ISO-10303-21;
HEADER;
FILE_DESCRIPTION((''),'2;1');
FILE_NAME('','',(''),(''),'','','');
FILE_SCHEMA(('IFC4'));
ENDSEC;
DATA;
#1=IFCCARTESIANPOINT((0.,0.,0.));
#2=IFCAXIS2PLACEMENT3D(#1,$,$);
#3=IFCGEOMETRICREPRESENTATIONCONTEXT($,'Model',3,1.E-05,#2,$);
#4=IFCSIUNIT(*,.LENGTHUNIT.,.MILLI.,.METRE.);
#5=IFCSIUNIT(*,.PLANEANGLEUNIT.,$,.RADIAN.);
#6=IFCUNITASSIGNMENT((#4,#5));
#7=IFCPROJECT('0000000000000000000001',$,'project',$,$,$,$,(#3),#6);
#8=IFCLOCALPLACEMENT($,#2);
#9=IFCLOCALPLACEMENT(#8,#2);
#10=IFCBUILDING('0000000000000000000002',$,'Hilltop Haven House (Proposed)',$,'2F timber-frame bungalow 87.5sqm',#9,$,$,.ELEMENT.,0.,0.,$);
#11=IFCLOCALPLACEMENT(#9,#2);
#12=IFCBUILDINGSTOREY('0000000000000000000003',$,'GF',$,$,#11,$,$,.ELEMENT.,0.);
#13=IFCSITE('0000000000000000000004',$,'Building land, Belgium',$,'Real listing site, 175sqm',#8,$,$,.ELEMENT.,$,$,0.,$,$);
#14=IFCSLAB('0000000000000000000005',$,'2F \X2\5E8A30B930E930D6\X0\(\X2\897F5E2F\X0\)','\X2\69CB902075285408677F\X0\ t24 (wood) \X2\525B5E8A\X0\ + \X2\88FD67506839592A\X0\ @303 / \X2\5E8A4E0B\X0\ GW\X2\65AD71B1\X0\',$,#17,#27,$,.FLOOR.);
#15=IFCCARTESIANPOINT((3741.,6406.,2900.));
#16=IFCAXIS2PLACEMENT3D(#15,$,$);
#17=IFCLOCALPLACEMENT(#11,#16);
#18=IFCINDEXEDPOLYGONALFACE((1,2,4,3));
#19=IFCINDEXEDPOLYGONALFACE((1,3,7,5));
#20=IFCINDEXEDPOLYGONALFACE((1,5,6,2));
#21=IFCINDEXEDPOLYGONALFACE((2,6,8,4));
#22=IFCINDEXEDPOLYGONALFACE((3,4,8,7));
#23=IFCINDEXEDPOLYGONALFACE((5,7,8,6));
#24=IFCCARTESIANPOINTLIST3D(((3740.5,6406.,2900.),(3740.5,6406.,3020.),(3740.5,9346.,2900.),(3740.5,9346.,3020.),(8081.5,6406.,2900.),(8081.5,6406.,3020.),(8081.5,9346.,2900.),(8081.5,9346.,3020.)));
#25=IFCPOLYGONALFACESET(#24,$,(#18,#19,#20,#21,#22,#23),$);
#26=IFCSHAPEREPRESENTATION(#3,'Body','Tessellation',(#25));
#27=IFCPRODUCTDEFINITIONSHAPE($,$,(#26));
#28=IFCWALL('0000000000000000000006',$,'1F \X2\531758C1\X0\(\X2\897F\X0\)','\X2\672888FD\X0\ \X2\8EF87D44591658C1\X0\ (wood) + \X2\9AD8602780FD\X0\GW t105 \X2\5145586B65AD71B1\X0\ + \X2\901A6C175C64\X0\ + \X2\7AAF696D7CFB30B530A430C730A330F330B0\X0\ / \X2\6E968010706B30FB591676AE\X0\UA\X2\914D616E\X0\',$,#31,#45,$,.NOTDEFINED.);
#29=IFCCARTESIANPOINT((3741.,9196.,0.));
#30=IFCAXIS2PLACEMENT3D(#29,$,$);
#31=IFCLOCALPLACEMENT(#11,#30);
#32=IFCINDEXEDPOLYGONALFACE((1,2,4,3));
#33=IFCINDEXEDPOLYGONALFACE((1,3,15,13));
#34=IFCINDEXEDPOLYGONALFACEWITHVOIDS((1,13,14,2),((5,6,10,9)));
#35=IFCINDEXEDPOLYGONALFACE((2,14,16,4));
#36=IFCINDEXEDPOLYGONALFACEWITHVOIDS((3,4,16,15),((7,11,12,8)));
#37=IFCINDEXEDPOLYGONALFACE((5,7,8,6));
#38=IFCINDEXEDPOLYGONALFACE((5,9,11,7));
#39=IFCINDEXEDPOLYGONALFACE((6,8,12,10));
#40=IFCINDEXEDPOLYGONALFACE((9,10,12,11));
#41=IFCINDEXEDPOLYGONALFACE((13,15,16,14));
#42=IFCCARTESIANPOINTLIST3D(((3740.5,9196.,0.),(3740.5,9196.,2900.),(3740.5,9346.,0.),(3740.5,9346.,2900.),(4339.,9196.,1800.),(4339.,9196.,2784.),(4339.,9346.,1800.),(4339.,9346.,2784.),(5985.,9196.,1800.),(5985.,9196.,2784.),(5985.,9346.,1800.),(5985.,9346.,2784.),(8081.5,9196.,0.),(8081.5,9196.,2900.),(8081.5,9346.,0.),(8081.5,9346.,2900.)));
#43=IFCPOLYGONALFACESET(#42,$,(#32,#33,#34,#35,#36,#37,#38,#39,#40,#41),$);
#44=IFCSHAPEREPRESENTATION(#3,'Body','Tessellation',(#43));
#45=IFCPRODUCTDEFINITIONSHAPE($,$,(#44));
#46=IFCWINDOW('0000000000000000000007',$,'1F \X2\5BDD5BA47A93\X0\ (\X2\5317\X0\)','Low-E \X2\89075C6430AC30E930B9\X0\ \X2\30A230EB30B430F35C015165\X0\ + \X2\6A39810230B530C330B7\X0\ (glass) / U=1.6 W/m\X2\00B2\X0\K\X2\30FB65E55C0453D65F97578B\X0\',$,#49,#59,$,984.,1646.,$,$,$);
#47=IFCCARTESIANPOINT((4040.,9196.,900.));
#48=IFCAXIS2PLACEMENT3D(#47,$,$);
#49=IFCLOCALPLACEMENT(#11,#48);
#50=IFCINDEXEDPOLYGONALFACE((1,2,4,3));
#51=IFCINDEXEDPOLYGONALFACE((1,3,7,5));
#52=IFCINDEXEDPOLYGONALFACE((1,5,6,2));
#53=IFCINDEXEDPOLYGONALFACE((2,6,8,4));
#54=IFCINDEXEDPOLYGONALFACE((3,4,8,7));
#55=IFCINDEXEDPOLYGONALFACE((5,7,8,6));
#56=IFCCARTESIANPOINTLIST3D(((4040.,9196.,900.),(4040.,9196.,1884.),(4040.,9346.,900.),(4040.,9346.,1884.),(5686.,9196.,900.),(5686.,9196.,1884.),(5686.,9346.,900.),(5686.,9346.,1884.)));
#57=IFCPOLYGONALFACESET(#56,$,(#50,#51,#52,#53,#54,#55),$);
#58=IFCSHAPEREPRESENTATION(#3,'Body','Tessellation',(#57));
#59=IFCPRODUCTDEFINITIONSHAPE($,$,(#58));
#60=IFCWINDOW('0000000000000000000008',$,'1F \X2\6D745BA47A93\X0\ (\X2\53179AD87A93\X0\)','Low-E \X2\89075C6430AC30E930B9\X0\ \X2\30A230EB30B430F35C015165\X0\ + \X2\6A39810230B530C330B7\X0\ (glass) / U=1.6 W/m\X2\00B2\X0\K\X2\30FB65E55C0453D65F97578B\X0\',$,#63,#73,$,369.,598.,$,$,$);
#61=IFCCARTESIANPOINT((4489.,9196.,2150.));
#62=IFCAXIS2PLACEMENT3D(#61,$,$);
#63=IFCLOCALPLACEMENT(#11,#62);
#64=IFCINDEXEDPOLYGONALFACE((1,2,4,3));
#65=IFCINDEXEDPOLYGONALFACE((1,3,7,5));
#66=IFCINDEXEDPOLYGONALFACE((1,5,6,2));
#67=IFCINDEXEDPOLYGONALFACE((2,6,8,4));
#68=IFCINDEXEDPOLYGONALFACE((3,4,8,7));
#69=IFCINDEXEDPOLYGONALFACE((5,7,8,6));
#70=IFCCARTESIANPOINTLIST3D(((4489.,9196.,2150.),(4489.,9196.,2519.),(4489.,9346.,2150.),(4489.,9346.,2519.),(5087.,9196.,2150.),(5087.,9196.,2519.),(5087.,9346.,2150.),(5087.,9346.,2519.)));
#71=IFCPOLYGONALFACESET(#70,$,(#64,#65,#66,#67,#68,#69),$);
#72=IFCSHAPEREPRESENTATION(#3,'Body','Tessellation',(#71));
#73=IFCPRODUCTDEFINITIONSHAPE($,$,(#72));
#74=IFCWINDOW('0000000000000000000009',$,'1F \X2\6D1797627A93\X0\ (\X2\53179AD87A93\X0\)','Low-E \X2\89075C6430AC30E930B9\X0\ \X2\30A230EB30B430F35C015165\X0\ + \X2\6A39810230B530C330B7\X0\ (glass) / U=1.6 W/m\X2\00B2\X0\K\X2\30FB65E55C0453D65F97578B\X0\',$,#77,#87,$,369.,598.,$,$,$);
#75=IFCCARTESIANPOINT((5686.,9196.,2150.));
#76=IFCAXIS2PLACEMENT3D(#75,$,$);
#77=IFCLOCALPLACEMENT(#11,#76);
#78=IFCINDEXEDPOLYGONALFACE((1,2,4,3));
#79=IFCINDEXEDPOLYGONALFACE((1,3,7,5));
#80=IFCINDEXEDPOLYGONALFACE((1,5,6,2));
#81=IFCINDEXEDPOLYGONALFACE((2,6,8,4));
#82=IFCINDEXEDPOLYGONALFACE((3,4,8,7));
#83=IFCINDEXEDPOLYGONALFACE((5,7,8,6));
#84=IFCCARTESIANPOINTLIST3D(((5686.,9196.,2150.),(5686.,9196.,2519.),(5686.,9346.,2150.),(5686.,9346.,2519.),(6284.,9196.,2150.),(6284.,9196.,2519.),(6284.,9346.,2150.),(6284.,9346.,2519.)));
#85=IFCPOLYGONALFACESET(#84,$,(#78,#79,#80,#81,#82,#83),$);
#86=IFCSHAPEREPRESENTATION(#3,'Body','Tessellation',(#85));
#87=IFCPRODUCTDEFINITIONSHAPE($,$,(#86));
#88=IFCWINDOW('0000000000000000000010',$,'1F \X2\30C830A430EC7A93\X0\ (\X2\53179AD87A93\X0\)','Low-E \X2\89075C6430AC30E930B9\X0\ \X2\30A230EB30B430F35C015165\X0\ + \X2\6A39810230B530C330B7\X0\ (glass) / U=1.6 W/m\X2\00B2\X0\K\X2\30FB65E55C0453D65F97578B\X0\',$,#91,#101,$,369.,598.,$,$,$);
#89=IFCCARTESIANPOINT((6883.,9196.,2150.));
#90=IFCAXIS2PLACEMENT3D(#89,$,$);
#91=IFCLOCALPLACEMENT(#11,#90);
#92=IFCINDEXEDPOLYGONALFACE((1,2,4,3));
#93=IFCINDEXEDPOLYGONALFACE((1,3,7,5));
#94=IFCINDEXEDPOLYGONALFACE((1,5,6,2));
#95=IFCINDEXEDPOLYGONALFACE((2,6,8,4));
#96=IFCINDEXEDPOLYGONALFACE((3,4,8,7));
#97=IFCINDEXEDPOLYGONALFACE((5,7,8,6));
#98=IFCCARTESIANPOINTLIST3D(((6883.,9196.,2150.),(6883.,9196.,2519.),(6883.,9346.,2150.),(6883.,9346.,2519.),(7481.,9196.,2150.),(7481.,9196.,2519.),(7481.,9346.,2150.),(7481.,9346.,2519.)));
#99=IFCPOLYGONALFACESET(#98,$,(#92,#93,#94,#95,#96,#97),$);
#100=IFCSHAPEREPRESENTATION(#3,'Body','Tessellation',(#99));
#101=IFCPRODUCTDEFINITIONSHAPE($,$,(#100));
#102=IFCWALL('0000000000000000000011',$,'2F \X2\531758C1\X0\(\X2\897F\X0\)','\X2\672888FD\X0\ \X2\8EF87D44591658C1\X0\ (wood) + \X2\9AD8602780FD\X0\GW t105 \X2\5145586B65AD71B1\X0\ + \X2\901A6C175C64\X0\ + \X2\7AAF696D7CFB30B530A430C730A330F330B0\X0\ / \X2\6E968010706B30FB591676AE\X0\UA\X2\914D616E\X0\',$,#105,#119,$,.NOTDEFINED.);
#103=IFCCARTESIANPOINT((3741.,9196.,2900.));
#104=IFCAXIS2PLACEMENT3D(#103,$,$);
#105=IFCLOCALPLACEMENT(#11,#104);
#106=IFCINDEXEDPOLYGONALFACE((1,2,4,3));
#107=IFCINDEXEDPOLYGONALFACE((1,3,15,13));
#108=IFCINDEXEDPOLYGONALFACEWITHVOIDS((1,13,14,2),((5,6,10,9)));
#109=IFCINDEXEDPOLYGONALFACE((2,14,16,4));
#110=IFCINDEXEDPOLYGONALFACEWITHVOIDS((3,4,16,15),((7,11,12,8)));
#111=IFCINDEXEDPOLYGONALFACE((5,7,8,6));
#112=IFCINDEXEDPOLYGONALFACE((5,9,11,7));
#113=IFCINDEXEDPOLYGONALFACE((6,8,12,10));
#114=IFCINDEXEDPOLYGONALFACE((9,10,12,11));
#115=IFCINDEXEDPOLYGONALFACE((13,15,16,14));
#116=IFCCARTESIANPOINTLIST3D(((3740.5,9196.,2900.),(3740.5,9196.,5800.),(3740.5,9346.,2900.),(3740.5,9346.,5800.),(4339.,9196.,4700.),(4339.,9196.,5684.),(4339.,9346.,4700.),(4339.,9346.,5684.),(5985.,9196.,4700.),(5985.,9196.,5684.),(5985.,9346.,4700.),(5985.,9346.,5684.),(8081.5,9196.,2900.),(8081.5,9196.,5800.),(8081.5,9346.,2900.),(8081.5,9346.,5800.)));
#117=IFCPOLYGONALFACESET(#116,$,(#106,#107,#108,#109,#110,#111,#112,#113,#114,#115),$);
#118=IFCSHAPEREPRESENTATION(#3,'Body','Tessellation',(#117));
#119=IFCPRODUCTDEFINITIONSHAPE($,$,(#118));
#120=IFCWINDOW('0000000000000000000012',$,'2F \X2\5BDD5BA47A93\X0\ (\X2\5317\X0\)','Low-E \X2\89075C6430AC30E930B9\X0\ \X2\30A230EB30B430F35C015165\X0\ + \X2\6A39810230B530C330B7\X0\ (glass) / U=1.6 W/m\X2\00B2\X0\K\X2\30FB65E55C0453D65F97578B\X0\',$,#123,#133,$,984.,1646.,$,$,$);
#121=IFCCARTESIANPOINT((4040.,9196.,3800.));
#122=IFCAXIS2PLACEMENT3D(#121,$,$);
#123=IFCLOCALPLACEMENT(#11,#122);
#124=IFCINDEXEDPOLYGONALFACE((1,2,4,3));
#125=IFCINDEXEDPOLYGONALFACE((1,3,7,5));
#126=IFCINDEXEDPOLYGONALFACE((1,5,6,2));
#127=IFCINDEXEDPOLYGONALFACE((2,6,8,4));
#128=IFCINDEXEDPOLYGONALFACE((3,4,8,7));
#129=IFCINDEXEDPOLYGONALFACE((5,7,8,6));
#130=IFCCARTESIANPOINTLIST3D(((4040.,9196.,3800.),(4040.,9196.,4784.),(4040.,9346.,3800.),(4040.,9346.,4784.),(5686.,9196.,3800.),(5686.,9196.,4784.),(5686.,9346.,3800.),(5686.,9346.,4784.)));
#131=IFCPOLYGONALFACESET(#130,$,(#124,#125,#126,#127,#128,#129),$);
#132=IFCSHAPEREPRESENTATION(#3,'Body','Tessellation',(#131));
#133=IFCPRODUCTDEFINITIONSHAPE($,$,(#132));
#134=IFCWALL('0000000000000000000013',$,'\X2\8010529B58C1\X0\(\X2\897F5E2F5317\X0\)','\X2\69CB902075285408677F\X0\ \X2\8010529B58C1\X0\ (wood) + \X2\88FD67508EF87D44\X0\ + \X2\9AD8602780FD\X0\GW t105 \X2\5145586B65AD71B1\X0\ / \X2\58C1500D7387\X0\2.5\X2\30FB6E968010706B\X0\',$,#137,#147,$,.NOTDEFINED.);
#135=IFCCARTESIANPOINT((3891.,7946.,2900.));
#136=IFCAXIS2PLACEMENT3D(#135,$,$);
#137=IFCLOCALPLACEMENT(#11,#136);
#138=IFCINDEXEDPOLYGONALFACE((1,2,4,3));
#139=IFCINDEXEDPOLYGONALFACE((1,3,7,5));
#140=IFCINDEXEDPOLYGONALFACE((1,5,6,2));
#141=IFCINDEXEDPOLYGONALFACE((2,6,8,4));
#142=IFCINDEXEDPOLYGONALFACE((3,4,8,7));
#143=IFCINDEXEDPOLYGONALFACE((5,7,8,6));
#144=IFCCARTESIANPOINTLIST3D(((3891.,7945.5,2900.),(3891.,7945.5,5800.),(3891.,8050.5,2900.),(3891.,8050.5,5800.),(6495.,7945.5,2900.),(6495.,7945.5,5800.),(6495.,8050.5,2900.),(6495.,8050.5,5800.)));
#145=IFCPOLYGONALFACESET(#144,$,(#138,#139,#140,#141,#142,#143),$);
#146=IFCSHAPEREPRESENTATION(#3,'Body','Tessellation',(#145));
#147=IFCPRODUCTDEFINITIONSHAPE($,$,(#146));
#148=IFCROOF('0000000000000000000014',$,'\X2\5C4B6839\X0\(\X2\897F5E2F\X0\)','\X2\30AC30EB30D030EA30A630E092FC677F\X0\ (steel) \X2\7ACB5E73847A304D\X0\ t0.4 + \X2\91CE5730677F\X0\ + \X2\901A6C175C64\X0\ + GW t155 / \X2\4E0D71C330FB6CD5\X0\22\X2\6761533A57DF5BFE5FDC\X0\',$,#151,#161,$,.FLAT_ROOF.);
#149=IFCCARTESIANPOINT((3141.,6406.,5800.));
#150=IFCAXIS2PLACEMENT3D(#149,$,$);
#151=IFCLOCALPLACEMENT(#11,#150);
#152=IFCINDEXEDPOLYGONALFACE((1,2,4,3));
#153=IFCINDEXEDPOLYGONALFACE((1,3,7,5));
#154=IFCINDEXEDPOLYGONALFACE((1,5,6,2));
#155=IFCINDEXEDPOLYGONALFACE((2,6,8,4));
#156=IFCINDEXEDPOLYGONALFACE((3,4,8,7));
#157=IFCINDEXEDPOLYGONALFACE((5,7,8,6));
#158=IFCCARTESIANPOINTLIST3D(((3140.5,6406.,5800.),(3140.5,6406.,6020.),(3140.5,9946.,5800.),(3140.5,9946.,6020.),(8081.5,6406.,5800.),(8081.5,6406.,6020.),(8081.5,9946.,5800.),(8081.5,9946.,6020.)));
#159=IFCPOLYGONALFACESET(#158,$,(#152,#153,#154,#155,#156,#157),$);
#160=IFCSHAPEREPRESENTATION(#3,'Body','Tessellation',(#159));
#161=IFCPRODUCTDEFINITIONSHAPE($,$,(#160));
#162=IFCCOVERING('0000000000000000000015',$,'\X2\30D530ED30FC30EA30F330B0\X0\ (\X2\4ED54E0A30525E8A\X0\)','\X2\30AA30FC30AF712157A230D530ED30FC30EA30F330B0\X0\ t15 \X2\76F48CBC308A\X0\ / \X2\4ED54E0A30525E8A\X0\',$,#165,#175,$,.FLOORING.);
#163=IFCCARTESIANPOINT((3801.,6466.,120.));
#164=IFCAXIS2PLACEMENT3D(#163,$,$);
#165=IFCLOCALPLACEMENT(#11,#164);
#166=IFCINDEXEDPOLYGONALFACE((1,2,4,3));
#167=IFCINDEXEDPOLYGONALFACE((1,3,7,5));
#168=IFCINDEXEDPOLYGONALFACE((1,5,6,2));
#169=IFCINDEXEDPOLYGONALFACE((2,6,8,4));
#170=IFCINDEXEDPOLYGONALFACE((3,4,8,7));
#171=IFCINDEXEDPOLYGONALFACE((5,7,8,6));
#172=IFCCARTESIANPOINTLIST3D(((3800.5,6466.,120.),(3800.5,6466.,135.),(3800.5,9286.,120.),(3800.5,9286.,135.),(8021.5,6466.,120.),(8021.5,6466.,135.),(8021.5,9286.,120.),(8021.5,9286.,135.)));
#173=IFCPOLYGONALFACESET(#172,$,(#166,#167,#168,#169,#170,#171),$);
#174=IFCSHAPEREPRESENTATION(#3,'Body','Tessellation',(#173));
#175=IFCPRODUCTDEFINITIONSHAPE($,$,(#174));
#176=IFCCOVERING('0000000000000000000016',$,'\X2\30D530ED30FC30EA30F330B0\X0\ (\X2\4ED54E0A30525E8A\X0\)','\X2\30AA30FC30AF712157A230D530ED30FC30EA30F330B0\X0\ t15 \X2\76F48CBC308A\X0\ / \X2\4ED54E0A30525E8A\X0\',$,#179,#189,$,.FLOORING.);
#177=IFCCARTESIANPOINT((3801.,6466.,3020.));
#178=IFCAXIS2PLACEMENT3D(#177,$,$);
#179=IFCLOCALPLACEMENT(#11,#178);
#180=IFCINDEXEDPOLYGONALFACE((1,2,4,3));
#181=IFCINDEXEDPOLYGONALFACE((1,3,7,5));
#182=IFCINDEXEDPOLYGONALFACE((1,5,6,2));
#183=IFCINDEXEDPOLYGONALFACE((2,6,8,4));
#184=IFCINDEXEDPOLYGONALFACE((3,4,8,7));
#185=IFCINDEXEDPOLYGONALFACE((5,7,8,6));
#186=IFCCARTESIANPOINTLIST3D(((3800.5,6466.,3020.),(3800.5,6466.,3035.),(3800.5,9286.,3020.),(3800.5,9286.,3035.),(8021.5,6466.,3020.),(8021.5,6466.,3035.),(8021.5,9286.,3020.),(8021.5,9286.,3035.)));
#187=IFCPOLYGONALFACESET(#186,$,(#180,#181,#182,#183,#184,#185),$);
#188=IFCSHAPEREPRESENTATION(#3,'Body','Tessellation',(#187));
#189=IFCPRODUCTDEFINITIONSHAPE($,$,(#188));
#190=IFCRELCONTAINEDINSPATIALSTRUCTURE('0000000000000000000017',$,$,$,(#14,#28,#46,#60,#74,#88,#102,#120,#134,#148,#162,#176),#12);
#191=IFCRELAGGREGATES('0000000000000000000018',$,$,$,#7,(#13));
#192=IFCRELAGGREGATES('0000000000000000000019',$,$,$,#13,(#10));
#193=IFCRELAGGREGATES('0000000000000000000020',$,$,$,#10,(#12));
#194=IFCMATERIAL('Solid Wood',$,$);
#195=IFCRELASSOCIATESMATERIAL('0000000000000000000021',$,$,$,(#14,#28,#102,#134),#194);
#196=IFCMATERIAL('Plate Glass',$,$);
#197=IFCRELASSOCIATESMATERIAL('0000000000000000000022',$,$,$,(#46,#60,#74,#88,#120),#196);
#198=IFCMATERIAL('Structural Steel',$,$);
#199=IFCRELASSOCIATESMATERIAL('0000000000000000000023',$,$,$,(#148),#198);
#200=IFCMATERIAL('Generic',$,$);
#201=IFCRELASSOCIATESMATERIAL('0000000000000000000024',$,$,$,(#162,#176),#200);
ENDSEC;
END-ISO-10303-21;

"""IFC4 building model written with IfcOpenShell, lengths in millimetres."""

from ifc_helpers import new_model, si_unit, frame, frame_2d, origin, place, context, project, spatial, rectangle, extrude, material, element, fill, save


model = new_model("IFC4")

# Units and contexts
model_context = context("Model", 3, precision=1e-05, world=origin())
ifc_project = project(units=[si_unit("LENGTHUNIT", "METRE", prefix="MILLI"), si_unit("PLANEANGLEUNIT", "RADIAN")], contexts=[model_context])

# Site, building, storey
site_placement = place(None, origin())
site = spatial("IfcSite", under=ifc_project, at=site_placement, Name="Building land, Belgium", ObjectType="Real listing site, 175sqm", CompositionType="ELEMENT", RefElevation=0.0)
building_placement = place(site_placement, origin())
building = spatial("IfcBuilding", under=site, at=building_placement, Name="Hilltop Haven House (Proposed)", ObjectType="2F timber-frame bungalow 87.5sqm", CompositionType="ELEMENT", ElevationOfRefHeight=0.0, ElevationOfTerrain=0.0)
storey_placement = place(building_placement, origin())
storey = spatial("IfcBuildingStorey", under=building, at=storey_placement, Name="GF", CompositionType="ELEMENT", Elevation=0.0)

# Slab
ifc_material_1 = material(Name="Solid Wood")
slab_1_placement = place(storey_placement, frame((3741.0, 6406.0, 2900.0)))
element("IfcSlab", 1, at=slab_1_placement, inside=storey, material=ifc_material_1, Name="2F 床スラブ(西帯)", Description="構造用合板 t24 (wood) 剛床 + 製材根太 @303 / 床下 GW断熱", PredefinedType="FLOOR", context=model_context, shape_type="SweptSolid", body=[
    extrude(rectangle(XDim=4341.0, YDim=2940.0, at=frame_2d((2170.0, 1470.0))), frame((3741.0, 6406.0, 2900.0)), (0.0, 0.0, 1.0), 120.0),
])

# Wall, openings, windows
wall_1_placement = place(storey_placement, frame((3741.0, 9196.0, 0.0)))
wall_1 = element("IfcWall", 2, at=wall_1_placement, inside=storey, material=ifc_material_1, Name="1F 北壁(西)", Description="木製 軸組外壁 (wood) + 高性能GW t105 充填断熱 + 通気層 + 窯業系サイディング / 準耐火・外皮UA配慮", PredefinedType="NOTDEFINED", context=model_context, shape_type="SweptSolid", body=[
    extrude(rectangle(XDim=4341.0, YDim=150.0, at=frame_2d((2170.0, 75.0))), frame((3741.0, 9196.0, 0.0)), (0.0, 0.0, 1.0), 2900.0),
])
opening_1_placement = place(storey_placement, frame((4040.0, 9196.0, 900.0)))
opening_1 = element("IfcOpeningElement", 3, at=opening_1_placement, cuts=wall_1, PredefinedType="NOTDEFINED", context=model_context, shape_type="SweptSolid", body=[
    extrude(rectangle(XDim=1646.0, YDim=150.0, at=frame_2d((823.0, 75.0))), frame((4040.0, 9196.0, 900.0)), (0.0, 0.0, 1.0), 984.0),
])
opening_2_placement = place(storey_placement, frame((4489.0, 9196.0, 2150.0)))
opening_2 = element("IfcOpeningElement", 4, at=opening_2_placement, cuts=wall_1, PredefinedType="NOTDEFINED", context=model_context, shape_type="SweptSolid", body=[
    extrude(rectangle(XDim=598.0, YDim=150.0, at=frame_2d((299.0, 75.0))), frame((4489.0, 9196.0, 2150.0)), (0.0, 0.0, 1.0), 369.0),
])
opening_3_placement = place(storey_placement, frame((5686.0, 9196.0, 2150.0)))
opening_3 = element("IfcOpeningElement", 5, at=opening_3_placement, cuts=wall_1, PredefinedType="NOTDEFINED", context=model_context, shape_type="SweptSolid", body=[
    extrude(rectangle(XDim=598.0, YDim=150.0, at=frame_2d((299.0, 75.0))), frame((5686.0, 9196.0, 2150.0)), (0.0, 0.0, 1.0), 369.0),
])
opening_4_placement = place(storey_placement, frame((6883.0, 9196.0, 2150.0)))
opening_4 = element("IfcOpeningElement", 6, at=opening_4_placement, cuts=wall_1, PredefinedType="NOTDEFINED", context=model_context, shape_type="SweptSolid", body=[
    extrude(rectangle(XDim=598.0, YDim=150.0, at=frame_2d((299.0, 75.0))), frame((6883.0, 9196.0, 2150.0)), (0.0, 0.0, 1.0), 369.0),
])
ifc_material_2 = material(Name="Plate Glass")
window_1_placement = place(storey_placement, frame((4040.0, 9196.0, 900.0)))
window_1 = element("IfcWindow", 7, at=window_1_placement, inside=storey, material=ifc_material_2, Name="1F 寝室窓 (北)", Description="Low-E 複層ガラス アルゴン封入 + 樹脂サッシ (glass) / U=1.6 W/m²K・日射取得型", OverallHeight=984.0, OverallWidth=1646.0, context=model_context, shape_type="SweptSolid", body=[
    extrude(rectangle(XDim=1646.0, YDim=150.0, at=frame_2d((823.0, 75.0))), frame((4040.0, 9196.0, 900.0)), (0.0, 0.0, 1.0), 984.0),
])
fill(opening_1, window_1)
window_2_placement = place(storey_placement, frame((4489.0, 9196.0, 2150.0)))
window_2 = element("IfcWindow", 8, at=window_2_placement, inside=storey, material=ifc_material_2, Name="1F 浴室窓 (北高窓)", Description="Low-E 複層ガラス アルゴン封入 + 樹脂サッシ (glass) / U=1.6 W/m²K・日射取得型", OverallHeight=369.0, OverallWidth=598.0, context=model_context, shape_type="SweptSolid", body=[
    extrude(rectangle(XDim=598.0, YDim=150.0, at=frame_2d((299.0, 75.0))), frame((4489.0, 9196.0, 2150.0)), (0.0, 0.0, 1.0), 369.0),
])
fill(opening_2, window_2)
window_3_placement = place(storey_placement, frame((5686.0, 9196.0, 2150.0)))
window_3 = element("IfcWindow", 9, at=window_3_placement, inside=storey, material=ifc_material_2, Name="1F 洗面窓 (北高窓)", Description="Low-E 複層ガラス アルゴン封入 + 樹脂サッシ (glass) / U=1.6 W/m²K・日射取得型", OverallHeight=369.0, OverallWidth=598.0, context=model_context, shape_type="SweptSolid", body=[
    extrude(rectangle(XDim=598.0, YDim=150.0, at=frame_2d((299.0, 75.0))), frame((5686.0, 9196.0, 2150.0)), (0.0, 0.0, 1.0), 369.0),
])
fill(opening_3, window_3)
window_4_placement = place(storey_placement, frame((6883.0, 9196.0, 2150.0)))
window_4 = element("IfcWindow", 10, at=window_4_placement, inside=storey, material=ifc_material_2, Name="1F トイレ窓 (北高窓)", Description="Low-E 複層ガラス アルゴン封入 + 樹脂サッシ (glass) / U=1.6 W/m²K・日射取得型", OverallHeight=369.0, OverallWidth=598.0, context=model_context, shape_type="SweptSolid", body=[
    extrude(rectangle(XDim=598.0, YDim=150.0, at=frame_2d((299.0, 75.0))), frame((6883.0, 9196.0, 2150.0)), (0.0, 0.0, 1.0), 369.0),
])
fill(opening_4, window_4)

# Wall, opening, window
wall_2_placement = place(storey_placement, frame((3741.0, 9196.0, 2900.0)))
wall_2 = element("IfcWall", 11, at=wall_2_placement, inside=storey, material=ifc_material_1, Name="2F 北壁(西)", Description="木製 軸組外壁 (wood) + 高性能GW t105 充填断熱 + 通気層 + 窯業系サイディング / 準耐火・外皮UA配慮", PredefinedType="NOTDEFINED", context=model_context, shape_type="SweptSolid", body=[
    extrude(rectangle(XDim=4341.0, YDim=150.0, at=frame_2d((2170.0, 75.0))), frame((3741.0, 9196.0, 2900.0)), (0.0, 0.0, 1.0), 2900.0),
])
opening_5_placement = place(storey_placement, frame((4040.0, 9196.0, 3800.0)))
opening_5 = element("IfcOpeningElement", 12, at=opening_5_placement, cuts=wall_2, PredefinedType="NOTDEFINED", context=model_context, shape_type="SweptSolid", body=[
    extrude(rectangle(XDim=1646.0, YDim=150.0, at=frame_2d((823.0, 75.0))), frame((4040.0, 9196.0, 3800.0)), (0.0, 0.0, 1.0), 984.0),
])
window_5_placement = place(storey_placement, frame((4040.0, 9196.0, 3800.0)))
window_5 = element("IfcWindow", 13, at=window_5_placement, inside=storey, material=ifc_material_2, Name="2F 寝室窓 (北)", Description="Low-E 複層ガラス アルゴン封入 + 樹脂サッシ (glass) / U=1.6 W/m²K・日射取得型", OverallHeight=984.0, OverallWidth=1646.0, context=model_context, shape_type="SweptSolid", body=[
    extrude(rectangle(XDim=1646.0, YDim=150.0, at=frame_2d((823.0, 75.0))), frame((4040.0, 9196.0, 3800.0)), (0.0, 0.0, 1.0), 984.0),
])
fill(opening_5, window_5)

# Wall
wall_3_placement = place(storey_placement, frame((3891.0, 7946.0, 2900.0)))
element("IfcWall", 14, at=wall_3_placement, inside=storey, material=ifc_material_1, Name="耐力壁(西帯北)", Description="構造用合板 耐力壁 (wood) + 製材軸組 + 高性能GW t105 充填断熱 / 壁倍率2.5・準耐火", PredefinedType="NOTDEFINED", context=model_context, shape_type="SweptSolid", body=[
    extrude(rectangle(XDim=2604.0, YDim=105.0, at=frame_2d((1302.0, 52.0))), frame((3891.0, 7946.0, 2900.0)), (0.0, 0.0, 1.0), 2900.0),
])

# Roof
ifc_material_3 = material(Name="Structural Steel")
for number, where, name in (
    (15, (3141.0, 6406.0, 5800.0), "屋根(西帯)"),
):
    element("IfcRoof", number, at=place(storey_placement, frame(where)), inside=storey, material=ifc_material_3, Name=name, Description="ガルバリウム鋼板 (steel) 立平葺き t0.4 + 野地板 + 通気層 + GW t155 / 不燃・法22条区域対応", PredefinedType="FLAT_ROOF", context=model_context, shape_type="SweptSolid", body=[
        extrude(rectangle(XDim=4941.0, YDim=3540.0, at=frame_2d((2470.0, 1770.0))), frame((3141.0, 6406.0, 5800.0)), (0.0, 0.0, 1.0), 220.0),
    ])

# Coverings
ifc_material_4 = material(Name="Generic")
covering_1_placement = place(storey_placement, frame((3801.0, 6466.0, 120.0)))
element("IfcCovering", 16, at=covering_1_placement, inside=storey, material=ifc_material_4, Name="フローリング (仕上げ床)", Description="オーク無垢フローリング t15 直貼り / 仕上げ床", PredefinedType="FLOORING", context=model_context, shape_type="SweptSolid", body=[
    extrude(rectangle(XDim=4221.0, YDim=2820.0, at=frame_2d((2110.0, 1410.0))), frame((3801.0, 6466.0, 120.0)), (0.0, 0.0, 1.0), 15.0),
])
covering_2_placement = place(storey_placement, frame((3801.0, 6466.0, 3020.0)))
element("IfcCovering", 17, at=covering_2_placement, inside=storey, material=ifc_material_4, Name="フローリング (仕上げ床)", Description="オーク無垢フローリング t15 直貼り / 仕上げ床", PredefinedType="FLOORING", context=model_context, shape_type="SweptSolid", body=[
    extrude(rectangle(XDim=4221.0, YDim=2820.0, at=frame_2d((2110.0, 1410.0))), frame((3801.0, 6466.0, 3020.0)), (0.0, 0.0, 1.0), 15.0),
])

save(model, "model.ifc")
